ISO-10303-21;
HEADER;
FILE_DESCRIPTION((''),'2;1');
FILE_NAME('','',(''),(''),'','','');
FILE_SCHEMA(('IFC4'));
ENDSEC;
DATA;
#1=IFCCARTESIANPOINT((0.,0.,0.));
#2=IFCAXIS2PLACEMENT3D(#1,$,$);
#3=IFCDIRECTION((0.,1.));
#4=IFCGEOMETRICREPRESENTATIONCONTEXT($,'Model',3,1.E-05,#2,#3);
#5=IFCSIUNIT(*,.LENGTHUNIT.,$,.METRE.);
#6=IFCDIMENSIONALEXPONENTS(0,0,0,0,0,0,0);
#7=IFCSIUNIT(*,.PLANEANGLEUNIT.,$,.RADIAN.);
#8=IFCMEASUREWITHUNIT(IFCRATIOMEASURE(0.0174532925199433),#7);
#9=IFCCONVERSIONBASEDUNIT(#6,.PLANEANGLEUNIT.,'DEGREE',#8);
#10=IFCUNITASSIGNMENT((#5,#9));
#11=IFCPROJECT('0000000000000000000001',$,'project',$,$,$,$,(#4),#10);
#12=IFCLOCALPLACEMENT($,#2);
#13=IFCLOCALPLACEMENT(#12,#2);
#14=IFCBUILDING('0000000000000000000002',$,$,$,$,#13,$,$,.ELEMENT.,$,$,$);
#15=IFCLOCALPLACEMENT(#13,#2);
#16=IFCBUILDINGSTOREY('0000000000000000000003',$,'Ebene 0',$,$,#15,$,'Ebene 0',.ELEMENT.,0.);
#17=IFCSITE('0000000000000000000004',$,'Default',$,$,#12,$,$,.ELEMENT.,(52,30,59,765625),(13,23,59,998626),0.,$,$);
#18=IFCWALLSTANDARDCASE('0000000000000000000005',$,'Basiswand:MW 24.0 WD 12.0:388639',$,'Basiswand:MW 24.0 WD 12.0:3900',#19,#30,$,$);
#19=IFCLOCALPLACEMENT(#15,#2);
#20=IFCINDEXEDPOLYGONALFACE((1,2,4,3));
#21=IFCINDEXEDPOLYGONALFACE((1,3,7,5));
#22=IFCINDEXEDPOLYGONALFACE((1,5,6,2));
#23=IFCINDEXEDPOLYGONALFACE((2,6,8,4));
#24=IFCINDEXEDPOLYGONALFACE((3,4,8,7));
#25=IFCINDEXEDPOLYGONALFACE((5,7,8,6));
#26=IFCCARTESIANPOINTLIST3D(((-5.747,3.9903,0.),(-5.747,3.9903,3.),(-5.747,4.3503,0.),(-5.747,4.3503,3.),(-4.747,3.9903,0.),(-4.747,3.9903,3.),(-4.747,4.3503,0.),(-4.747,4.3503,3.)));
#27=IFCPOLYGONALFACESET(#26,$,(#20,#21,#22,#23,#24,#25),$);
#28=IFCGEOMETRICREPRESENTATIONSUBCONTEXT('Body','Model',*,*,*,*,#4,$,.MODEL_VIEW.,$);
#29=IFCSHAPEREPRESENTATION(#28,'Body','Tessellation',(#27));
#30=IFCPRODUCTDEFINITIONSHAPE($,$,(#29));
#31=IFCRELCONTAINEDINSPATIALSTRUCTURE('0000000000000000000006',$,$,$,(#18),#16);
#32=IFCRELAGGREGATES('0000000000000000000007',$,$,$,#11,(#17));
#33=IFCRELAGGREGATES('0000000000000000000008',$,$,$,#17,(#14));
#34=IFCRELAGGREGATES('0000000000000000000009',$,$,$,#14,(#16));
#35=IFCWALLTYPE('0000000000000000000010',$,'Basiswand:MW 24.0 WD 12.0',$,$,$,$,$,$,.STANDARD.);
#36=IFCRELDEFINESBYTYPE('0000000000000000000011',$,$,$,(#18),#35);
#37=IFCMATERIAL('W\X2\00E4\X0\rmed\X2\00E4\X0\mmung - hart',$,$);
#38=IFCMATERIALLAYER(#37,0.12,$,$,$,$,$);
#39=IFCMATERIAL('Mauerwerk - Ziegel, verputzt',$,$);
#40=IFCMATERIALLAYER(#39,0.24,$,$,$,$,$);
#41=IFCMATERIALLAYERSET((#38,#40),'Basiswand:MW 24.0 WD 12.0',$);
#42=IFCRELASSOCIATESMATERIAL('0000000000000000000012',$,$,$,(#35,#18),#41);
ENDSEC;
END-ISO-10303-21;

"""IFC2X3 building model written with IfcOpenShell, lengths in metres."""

from ifc_helpers import new_model, entity, si_unit, converted_unit, direction, frame, frame_2d, origin, place, context, subcontext, project, spatial, rectangle, extrude, material, layer, layer_set, layer_usage, type_object, element, save


model = new_model("IFC2X3")

# Units and contexts
model_context = context("Model", 3, precision=1e-05, world=origin(), true_north=direction((0.0, 1.0)))
body_context = subcontext(model_context, "Body", "Model", "MODEL_VIEW")
ifc_project = project(units=[si_unit("LENGTHUNIT", "METRE"), converted_unit("PLANEANGLEUNIT", "DEGREE", entity("IfcRatioMeasure", 0.0174532925199433), si_unit("PLANEANGLEUNIT", "RADIAN"), dimensions=[0, 0, 0, 0, 0, 0, 0])], contexts=[model_context])

# Site, building, storey
site_placement = place(None, origin())
site = spatial("IfcSite", under=ifc_project, at=site_placement, Name="Default", CompositionType="ELEMENT", RefLatitude=(52, 30, 59, 765625), RefLongitude=(13, 23, 59, 998626), RefElevation=0.0)
building_placement = place(site_placement, origin())
building = spatial("IfcBuilding", under=site, at=building_placement, CompositionType="ELEMENT")
storey_placement = place(building_placement, origin())
storey = spatial("IfcBuildingStorey", under=building, at=storey_placement, Name="Ebene 0", LongName="Ebene 0", CompositionType="ELEMENT", Elevation=0.0)

# Wall
ifc_material_1 = material(Name="Wärmedämmung - hart")
ifc_layer_1 = layer(ifc_material_1, 0.12)
ifc_material_2 = material(Name="Mauerwerk - Ziegel, verputzt")
ifc_layer_2 = layer(ifc_material_2, 0.24)
ifc_layer_set = layer_set([ifc_layer_1, ifc_layer_2], Name="Basiswand:MW 24.0 WD 12.0")
ifc_layer_usage = layer_usage(ifc_layer_set, "AXIS2", "NEGATIVE", 0.18)
wall_type = type_object("IfcWallType", Name="Basiswand:MW 24.0 WD 12.0", PredefinedType="STANDARD", material=ifc_layer_set)
wall_placement = place(storey_placement, frame((-5.747, 4.1703, 0.0)))
element("IfcWallStandardCase", 1, at=wall_placement, inside=storey, type_object=wall_type, material=ifc_layer_usage, Name="Basiswand:MW 24.0 WD 12.0:388639", ObjectType="Basiswand:MW 24.0 WD 12.0:3900", context=body_context, shape_type="SweptSolid", body=[
    extrude(rectangle(XDim=1.0, YDim=0.36, at=frame_2d((0.5, 0.0), x_axis=(-1.0, 0.0))), origin(), (0.0, 0.0, 1.0), 3.0),
])

save(model, "model.ifc")
